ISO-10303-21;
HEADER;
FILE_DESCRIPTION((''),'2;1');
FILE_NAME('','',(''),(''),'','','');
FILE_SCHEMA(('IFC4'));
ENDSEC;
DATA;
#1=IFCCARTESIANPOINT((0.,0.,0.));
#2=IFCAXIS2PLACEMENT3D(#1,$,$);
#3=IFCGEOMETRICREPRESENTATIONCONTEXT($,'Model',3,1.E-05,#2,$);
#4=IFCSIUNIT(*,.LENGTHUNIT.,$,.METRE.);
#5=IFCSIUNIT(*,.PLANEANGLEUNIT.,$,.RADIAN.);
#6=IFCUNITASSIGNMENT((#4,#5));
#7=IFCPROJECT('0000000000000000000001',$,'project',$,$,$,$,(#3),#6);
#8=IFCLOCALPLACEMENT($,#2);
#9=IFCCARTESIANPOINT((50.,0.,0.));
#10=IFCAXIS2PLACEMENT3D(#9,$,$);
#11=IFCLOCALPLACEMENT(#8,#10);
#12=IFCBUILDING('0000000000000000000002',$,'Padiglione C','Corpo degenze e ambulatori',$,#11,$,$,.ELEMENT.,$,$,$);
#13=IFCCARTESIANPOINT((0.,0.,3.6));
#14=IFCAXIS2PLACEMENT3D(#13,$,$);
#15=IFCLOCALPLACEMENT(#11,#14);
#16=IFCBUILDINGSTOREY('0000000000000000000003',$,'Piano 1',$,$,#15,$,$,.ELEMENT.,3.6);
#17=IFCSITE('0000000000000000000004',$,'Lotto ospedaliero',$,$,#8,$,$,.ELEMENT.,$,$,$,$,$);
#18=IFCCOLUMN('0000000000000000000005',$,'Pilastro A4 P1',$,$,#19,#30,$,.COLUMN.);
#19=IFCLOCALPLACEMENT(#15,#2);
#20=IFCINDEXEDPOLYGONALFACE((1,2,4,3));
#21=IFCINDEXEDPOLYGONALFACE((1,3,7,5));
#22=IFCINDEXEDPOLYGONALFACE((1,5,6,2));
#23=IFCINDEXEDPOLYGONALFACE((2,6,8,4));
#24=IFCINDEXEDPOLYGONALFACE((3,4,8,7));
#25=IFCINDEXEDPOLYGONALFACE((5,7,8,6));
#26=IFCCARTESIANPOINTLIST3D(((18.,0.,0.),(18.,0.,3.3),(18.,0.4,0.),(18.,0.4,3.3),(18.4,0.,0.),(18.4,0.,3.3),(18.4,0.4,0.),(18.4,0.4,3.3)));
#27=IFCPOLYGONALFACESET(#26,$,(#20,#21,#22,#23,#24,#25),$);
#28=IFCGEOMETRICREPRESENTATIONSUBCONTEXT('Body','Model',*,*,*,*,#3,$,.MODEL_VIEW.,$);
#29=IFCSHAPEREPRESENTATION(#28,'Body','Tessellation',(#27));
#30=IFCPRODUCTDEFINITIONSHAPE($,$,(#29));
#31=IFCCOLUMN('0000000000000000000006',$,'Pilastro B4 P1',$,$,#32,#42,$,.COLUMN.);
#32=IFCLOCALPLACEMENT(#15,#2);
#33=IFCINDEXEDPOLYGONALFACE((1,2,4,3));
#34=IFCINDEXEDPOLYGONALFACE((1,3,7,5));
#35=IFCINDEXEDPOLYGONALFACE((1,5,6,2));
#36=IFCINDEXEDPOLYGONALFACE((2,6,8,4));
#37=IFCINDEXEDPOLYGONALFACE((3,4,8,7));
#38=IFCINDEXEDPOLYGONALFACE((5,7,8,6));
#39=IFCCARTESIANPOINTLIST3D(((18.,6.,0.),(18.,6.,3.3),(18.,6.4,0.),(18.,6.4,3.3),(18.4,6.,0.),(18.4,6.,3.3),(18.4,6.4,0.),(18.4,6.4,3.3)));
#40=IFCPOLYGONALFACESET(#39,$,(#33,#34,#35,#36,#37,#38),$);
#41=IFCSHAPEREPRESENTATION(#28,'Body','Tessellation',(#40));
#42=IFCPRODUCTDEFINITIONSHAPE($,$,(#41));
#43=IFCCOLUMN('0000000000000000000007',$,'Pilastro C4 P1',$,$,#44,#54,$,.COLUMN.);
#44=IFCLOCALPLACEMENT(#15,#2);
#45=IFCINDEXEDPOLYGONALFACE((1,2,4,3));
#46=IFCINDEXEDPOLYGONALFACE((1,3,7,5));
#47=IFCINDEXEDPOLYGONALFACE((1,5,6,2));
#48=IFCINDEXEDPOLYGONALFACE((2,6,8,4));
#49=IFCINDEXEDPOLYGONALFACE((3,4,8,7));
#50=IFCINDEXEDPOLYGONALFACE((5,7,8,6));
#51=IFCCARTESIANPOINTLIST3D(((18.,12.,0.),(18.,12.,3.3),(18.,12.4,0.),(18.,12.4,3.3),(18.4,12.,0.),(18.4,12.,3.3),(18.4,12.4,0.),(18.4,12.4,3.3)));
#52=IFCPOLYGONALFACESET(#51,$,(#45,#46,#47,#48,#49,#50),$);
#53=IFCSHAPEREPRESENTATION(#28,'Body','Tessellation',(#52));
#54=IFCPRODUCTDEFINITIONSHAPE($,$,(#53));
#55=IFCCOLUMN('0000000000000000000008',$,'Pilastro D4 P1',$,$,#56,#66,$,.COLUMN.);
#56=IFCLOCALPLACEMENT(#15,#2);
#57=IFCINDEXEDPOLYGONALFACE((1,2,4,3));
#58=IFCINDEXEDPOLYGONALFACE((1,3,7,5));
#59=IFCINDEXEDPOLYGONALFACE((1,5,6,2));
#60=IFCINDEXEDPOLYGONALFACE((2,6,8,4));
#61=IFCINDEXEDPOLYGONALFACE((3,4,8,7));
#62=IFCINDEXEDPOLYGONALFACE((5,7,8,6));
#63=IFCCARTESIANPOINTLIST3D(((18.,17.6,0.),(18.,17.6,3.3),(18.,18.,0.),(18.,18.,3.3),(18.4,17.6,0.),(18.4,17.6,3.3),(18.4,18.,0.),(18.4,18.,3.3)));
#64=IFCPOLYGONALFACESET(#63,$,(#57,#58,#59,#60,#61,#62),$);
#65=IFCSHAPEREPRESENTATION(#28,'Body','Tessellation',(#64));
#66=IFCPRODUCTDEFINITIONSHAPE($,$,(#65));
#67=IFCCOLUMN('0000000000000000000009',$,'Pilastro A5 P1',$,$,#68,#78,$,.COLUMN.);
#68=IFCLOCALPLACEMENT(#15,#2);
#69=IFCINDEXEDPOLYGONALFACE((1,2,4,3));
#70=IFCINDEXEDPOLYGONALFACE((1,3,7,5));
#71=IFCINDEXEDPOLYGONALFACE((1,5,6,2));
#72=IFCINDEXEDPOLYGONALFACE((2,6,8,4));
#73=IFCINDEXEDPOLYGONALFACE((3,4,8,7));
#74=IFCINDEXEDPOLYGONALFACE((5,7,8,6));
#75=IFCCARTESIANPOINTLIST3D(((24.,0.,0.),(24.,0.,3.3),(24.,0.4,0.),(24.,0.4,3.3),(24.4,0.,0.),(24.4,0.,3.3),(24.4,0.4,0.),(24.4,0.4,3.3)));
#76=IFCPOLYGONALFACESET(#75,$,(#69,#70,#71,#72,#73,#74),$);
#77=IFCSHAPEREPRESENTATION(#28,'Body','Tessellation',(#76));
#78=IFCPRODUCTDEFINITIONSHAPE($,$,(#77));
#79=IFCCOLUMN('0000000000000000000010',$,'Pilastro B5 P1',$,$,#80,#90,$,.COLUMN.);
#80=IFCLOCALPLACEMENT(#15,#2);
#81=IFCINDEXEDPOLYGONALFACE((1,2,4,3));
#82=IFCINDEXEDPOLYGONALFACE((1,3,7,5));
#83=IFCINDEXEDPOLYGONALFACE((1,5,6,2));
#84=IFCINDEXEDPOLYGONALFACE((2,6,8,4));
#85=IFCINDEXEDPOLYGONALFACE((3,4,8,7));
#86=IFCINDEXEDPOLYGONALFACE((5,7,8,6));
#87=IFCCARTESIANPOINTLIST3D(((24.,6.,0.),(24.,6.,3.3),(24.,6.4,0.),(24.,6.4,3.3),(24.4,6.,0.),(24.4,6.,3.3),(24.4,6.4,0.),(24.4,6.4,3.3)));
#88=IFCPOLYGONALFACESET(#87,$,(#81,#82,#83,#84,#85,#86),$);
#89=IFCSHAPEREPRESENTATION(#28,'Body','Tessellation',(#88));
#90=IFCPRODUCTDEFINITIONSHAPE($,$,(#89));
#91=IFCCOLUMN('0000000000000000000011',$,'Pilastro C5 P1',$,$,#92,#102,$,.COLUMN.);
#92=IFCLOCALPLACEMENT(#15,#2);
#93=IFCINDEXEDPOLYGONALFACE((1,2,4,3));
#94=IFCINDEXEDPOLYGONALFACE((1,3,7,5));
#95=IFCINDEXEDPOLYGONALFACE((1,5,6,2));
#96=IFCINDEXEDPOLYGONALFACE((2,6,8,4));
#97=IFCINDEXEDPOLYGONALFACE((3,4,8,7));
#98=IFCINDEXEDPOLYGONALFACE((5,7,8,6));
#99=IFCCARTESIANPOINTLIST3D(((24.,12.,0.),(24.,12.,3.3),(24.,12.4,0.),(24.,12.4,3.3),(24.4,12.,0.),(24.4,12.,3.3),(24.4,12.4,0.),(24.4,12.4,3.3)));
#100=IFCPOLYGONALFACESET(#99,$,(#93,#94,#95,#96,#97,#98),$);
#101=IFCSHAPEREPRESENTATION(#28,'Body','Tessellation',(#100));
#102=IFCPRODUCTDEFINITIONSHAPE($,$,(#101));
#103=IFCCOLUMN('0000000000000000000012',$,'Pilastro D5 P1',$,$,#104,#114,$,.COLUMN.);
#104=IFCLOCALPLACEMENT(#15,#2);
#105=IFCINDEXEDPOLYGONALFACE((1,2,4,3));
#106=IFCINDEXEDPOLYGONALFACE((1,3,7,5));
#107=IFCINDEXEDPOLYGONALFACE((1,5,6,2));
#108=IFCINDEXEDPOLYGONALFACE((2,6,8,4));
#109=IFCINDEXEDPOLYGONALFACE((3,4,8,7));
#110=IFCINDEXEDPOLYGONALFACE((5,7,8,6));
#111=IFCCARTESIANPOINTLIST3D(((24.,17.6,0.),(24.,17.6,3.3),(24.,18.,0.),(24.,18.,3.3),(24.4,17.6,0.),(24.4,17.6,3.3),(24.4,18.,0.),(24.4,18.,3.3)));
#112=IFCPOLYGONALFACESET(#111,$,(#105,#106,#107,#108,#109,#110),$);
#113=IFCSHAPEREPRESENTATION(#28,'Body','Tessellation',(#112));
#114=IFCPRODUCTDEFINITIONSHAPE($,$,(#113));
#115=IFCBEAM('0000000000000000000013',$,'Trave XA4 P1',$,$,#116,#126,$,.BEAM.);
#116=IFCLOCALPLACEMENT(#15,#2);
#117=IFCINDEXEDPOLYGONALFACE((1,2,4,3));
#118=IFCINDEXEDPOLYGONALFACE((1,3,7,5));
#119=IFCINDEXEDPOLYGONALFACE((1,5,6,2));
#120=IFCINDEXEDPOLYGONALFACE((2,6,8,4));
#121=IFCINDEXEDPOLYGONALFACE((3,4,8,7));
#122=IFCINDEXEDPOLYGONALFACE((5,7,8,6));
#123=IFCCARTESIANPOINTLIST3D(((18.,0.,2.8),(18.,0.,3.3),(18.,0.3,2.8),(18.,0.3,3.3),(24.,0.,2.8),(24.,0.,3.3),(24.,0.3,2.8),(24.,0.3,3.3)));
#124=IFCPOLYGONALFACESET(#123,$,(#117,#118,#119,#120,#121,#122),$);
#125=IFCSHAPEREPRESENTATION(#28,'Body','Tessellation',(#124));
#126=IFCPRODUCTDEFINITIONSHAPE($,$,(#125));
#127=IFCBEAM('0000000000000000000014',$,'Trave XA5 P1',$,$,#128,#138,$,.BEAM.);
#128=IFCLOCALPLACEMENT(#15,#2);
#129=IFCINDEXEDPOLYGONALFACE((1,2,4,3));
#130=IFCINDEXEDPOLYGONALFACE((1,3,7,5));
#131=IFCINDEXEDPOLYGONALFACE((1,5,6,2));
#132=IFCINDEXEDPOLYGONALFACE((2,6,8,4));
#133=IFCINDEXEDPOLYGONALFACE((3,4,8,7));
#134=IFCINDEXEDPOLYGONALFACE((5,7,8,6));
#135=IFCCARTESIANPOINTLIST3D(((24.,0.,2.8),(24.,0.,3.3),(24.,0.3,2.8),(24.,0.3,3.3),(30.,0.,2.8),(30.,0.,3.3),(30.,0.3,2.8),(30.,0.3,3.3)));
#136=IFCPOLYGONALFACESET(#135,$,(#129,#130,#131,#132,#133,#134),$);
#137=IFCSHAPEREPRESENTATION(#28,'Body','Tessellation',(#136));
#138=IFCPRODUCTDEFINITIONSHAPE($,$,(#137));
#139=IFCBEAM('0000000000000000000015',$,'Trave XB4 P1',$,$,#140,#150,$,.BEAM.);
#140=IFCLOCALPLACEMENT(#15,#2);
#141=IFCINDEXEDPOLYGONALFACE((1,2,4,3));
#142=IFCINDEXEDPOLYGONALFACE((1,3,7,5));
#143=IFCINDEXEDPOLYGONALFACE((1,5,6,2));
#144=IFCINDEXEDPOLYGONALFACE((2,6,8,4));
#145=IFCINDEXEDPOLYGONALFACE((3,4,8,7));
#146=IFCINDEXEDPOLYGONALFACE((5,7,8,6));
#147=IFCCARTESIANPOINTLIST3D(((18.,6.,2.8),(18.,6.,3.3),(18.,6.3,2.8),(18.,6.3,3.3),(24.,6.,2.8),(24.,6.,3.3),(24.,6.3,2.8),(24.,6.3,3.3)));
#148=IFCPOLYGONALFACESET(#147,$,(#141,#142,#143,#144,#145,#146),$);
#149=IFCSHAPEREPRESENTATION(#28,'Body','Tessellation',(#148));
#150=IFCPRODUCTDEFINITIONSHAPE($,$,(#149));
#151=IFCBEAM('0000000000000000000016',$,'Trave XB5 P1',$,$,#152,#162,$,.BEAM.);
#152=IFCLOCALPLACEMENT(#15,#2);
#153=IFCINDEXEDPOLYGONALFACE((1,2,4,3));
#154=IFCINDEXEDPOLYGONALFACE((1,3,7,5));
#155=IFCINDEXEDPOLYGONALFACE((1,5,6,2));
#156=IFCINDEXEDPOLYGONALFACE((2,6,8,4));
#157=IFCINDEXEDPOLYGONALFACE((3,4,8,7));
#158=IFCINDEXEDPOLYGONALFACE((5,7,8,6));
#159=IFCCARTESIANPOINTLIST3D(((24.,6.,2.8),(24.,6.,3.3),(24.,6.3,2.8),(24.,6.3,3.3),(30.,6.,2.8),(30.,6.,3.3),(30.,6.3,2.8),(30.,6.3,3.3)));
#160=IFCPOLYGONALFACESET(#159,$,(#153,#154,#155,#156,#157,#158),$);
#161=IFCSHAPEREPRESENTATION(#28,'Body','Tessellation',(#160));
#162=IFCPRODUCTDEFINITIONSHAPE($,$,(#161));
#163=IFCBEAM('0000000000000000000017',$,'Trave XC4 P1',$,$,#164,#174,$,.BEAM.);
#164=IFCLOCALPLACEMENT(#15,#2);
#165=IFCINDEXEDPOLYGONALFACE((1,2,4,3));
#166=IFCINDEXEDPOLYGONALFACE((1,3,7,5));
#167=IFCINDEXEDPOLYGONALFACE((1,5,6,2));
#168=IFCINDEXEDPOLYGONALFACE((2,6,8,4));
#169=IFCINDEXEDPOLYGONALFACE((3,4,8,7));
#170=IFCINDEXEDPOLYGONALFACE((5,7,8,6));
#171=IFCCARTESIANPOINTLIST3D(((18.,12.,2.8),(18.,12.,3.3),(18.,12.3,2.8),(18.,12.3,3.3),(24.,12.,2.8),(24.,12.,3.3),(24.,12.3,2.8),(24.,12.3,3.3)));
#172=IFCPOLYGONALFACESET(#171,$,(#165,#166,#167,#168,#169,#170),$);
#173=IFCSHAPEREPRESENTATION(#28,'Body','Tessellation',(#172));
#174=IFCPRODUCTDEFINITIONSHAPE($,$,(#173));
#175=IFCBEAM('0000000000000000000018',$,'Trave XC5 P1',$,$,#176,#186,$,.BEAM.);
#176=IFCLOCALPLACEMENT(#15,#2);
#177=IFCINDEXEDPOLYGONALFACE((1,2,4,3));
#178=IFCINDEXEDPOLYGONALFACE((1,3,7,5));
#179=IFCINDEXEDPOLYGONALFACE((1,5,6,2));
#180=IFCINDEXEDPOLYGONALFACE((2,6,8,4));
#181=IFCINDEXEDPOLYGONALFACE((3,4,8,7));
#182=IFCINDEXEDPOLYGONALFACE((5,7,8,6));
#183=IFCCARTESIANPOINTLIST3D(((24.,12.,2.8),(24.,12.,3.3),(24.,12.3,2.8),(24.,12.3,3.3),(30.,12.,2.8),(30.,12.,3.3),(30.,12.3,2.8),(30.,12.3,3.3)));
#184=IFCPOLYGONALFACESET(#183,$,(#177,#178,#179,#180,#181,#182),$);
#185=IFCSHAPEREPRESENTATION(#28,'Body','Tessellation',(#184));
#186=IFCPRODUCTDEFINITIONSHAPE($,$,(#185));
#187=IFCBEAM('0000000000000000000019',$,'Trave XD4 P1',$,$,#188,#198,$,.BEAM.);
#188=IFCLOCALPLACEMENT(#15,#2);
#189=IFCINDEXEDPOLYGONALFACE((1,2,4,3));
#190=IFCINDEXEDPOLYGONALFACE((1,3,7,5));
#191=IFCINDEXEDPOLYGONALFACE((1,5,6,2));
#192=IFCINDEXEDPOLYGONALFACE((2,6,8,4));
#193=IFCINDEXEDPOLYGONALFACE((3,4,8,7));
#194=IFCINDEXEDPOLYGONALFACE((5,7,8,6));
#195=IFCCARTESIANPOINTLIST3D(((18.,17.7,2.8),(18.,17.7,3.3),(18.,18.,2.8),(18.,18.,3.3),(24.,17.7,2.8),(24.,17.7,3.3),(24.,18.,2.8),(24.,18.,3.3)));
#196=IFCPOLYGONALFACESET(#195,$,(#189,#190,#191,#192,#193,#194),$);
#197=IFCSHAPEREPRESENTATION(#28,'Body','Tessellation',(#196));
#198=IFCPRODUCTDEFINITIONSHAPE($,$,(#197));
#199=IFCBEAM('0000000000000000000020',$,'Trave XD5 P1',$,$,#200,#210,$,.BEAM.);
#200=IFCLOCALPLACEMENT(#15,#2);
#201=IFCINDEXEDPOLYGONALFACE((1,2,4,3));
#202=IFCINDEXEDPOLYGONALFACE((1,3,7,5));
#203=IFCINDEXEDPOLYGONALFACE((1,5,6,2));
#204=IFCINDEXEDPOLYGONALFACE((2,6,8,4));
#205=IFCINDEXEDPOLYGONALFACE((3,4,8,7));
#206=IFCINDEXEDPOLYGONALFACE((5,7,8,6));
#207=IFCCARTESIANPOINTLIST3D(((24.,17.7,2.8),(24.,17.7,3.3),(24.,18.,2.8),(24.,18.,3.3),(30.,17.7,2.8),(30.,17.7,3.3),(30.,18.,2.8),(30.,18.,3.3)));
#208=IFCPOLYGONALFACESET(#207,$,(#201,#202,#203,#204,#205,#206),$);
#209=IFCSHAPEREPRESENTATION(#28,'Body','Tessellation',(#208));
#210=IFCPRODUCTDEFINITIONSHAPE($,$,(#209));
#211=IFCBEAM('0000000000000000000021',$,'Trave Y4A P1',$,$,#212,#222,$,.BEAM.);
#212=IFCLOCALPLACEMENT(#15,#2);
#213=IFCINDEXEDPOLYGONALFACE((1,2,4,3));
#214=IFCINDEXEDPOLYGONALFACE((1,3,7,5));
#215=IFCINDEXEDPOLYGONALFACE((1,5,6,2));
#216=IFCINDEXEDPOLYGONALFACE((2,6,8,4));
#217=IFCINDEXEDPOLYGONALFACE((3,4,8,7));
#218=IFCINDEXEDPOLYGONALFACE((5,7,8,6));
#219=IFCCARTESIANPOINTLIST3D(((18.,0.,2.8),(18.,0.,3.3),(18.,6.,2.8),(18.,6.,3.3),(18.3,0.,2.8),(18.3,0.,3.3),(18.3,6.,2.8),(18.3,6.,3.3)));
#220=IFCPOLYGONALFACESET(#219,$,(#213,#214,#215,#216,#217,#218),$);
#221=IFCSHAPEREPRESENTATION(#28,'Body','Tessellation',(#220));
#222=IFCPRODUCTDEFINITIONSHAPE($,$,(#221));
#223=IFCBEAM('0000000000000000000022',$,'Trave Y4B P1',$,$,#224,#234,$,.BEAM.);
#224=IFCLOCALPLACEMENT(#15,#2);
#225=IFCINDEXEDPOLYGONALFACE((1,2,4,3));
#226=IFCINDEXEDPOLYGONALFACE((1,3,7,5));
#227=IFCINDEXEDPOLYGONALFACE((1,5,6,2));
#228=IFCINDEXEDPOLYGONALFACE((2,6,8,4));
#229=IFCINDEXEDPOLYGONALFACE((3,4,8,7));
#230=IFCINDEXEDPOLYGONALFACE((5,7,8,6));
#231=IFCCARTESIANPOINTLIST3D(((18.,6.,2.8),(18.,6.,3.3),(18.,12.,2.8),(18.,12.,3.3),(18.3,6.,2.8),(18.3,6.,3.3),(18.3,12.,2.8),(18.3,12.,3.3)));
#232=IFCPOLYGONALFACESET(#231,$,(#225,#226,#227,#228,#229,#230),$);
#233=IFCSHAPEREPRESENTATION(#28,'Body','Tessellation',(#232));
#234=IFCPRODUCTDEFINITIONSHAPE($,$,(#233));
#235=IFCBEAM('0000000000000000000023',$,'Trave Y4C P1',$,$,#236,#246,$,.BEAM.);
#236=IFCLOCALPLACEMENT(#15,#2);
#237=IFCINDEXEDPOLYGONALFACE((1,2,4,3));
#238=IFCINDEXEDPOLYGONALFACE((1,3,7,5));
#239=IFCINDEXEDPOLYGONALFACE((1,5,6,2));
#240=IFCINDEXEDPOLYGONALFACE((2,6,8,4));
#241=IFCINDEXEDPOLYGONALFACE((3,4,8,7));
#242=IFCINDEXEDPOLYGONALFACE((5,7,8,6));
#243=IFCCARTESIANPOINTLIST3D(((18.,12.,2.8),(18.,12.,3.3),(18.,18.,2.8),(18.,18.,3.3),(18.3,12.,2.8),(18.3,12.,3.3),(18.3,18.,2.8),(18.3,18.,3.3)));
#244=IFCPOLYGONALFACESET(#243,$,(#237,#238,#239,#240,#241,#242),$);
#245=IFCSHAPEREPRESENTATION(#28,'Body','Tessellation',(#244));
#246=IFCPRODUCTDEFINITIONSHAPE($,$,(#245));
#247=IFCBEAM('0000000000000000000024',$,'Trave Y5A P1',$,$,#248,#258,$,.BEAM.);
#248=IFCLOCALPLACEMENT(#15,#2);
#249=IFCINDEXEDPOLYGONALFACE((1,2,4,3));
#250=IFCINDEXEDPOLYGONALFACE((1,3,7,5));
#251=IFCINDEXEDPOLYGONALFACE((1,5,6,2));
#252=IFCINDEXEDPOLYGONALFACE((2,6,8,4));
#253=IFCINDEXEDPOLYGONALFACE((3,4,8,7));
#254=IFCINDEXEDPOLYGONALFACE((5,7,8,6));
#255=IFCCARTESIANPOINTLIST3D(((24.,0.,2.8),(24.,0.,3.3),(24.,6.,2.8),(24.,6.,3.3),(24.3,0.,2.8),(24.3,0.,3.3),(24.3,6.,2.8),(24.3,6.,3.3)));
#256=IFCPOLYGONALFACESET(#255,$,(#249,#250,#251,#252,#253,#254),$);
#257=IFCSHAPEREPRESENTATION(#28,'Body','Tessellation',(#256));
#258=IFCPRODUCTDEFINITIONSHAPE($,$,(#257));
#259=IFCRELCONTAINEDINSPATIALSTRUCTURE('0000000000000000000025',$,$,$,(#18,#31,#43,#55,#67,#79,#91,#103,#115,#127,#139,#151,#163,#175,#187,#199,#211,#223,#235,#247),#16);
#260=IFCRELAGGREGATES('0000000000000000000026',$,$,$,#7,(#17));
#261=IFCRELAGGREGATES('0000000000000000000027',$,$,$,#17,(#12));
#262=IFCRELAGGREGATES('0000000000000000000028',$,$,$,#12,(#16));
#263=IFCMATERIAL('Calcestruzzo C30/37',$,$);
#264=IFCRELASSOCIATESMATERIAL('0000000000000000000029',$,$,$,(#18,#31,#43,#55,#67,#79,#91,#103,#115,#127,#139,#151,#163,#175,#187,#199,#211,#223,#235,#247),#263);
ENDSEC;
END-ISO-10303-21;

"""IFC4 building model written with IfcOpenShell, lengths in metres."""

from ifc_helpers import new_model, si_unit, frame, frame_2d, origin, place, context, subcontext, project, spatial, rectangle, extrude, material, element, save


model = new_model("IFC4")

# Units and contexts
model_context = context("Model", 3, precision=1e-05, world=origin())
body_context = subcontext(model_context, "Body", "Model", "MODEL_VIEW")
ifc_project = project(units=[si_unit("LENGTHUNIT", "METRE"), si_unit("PLANEANGLEUNIT", "RADIAN")], contexts=[model_context])

# Site, building, storey
site_placement = place(None, origin())
site = spatial("IfcSite", under=ifc_project, at=site_placement, Name="Lotto ospedaliero", CompositionType="ELEMENT")
building_placement = place(site_placement, frame((50.0, 0.0, 0.0)))
building = spatial("IfcBuilding", under=site, at=building_placement, Name="Padiglione C", Description="Corpo degenze e ambulatori", CompositionType="ELEMENT")
storey_placement = place(building_placement, frame((0.0, 0.0, 3.6)))
storey = spatial("IfcBuildingStorey", under=building, at=storey_placement, Name="Piano 1", CompositionType="ELEMENT", Elevation=3.6)

# Columns
ifc_material_1 = material(Name="Calcestruzzo C30/37")
for number, where, name in (
    (1, (18.0, 0.0, 0.0), "Pilastro A4 P1"),
    (2, (18.0, 6.0, 0.0), "Pilastro B4 P1"),
    (3, (18.0, 12.0, 0.0), "Pilastro C4 P1"),
    (4, (18.0, 17.6, 0.0), "Pilastro D4 P1"),
    (5, (24.0, 0.0, 0.0), "Pilastro A5 P1"),
    (6, (24.0, 6.0, 0.0), "Pilastro B5 P1"),
    (7, (24.0, 12.0, 0.0), "Pilastro C5 P1"),
    (8, (24.0, 17.6, 0.0), "Pilastro D5 P1"),
):
    element("IfcColumn", number, at=place(storey_placement, frame(where)), inside=storey, material=ifc_material_1, Name=name, PredefinedType="COLUMN", context=body_context, shape_type="SweptSolid", body=[
        extrude(rectangle(XDim=0.4, YDim=0.4, at=frame_2d((0.2, 0.2))), origin(), (0.0, 0.0, 1.0), 3.3),
    ])

# Beams
for number, where, name in (
    (9, (18.0, 0.0, 2.8), "Trave XA4 P1"),
    (10, (24.0, 0.0, 2.8), "Trave XA5 P1"),
    (11, (18.0, 6.0, 2.8), "Trave XB4 P1"),
    (12, (24.0, 6.0, 2.8), "Trave XB5 P1"),
    (13, (18.0, 12.0, 2.8), "Trave XC4 P1"),
    (14, (24.0, 12.0, 2.8), "Trave XC5 P1"),
    (15, (18.0, 17.7, 2.8), "Trave XD4 P1"),
    (16, (24.0, 17.7, 2.8), "Trave XD5 P1"),
):
    element("IfcBeam", number, at=place(storey_placement, frame(where)), inside=storey, material=ifc_material_1, Name=name, PredefinedType="BEAM", context=body_context, shape_type="SweptSolid", body=[
        extrude(rectangle(XDim=6.0, YDim=0.3, at=frame_2d((3.0, 0.15))), origin(), (0.0, 0.0, 1.0), 0.5),
    ])
for number, where, name in (
    (17, (18.0, 0.0, 2.8), "Trave Y4A P1"),
    (18, (18.0, 6.0, 2.8), "Trave Y4B P1"),
    (19, (18.0, 12.0, 2.8), "Trave Y4C P1"),
    (20, (24.0, 0.0, 2.8), "Trave Y5A P1"),
):
    element("IfcBeam", number, at=place(storey_placement, frame(where)), inside=storey, material=ifc_material_1, Name=name, PredefinedType="BEAM", context=body_context, shape_type="SweptSolid", body=[
        extrude(rectangle(XDim=0.3, YDim=6.0, at=frame_2d((0.15, 3.0))), origin(), (0.0, 0.0, 1.0), 0.5),
    ])

save(model, "model.ifc")
